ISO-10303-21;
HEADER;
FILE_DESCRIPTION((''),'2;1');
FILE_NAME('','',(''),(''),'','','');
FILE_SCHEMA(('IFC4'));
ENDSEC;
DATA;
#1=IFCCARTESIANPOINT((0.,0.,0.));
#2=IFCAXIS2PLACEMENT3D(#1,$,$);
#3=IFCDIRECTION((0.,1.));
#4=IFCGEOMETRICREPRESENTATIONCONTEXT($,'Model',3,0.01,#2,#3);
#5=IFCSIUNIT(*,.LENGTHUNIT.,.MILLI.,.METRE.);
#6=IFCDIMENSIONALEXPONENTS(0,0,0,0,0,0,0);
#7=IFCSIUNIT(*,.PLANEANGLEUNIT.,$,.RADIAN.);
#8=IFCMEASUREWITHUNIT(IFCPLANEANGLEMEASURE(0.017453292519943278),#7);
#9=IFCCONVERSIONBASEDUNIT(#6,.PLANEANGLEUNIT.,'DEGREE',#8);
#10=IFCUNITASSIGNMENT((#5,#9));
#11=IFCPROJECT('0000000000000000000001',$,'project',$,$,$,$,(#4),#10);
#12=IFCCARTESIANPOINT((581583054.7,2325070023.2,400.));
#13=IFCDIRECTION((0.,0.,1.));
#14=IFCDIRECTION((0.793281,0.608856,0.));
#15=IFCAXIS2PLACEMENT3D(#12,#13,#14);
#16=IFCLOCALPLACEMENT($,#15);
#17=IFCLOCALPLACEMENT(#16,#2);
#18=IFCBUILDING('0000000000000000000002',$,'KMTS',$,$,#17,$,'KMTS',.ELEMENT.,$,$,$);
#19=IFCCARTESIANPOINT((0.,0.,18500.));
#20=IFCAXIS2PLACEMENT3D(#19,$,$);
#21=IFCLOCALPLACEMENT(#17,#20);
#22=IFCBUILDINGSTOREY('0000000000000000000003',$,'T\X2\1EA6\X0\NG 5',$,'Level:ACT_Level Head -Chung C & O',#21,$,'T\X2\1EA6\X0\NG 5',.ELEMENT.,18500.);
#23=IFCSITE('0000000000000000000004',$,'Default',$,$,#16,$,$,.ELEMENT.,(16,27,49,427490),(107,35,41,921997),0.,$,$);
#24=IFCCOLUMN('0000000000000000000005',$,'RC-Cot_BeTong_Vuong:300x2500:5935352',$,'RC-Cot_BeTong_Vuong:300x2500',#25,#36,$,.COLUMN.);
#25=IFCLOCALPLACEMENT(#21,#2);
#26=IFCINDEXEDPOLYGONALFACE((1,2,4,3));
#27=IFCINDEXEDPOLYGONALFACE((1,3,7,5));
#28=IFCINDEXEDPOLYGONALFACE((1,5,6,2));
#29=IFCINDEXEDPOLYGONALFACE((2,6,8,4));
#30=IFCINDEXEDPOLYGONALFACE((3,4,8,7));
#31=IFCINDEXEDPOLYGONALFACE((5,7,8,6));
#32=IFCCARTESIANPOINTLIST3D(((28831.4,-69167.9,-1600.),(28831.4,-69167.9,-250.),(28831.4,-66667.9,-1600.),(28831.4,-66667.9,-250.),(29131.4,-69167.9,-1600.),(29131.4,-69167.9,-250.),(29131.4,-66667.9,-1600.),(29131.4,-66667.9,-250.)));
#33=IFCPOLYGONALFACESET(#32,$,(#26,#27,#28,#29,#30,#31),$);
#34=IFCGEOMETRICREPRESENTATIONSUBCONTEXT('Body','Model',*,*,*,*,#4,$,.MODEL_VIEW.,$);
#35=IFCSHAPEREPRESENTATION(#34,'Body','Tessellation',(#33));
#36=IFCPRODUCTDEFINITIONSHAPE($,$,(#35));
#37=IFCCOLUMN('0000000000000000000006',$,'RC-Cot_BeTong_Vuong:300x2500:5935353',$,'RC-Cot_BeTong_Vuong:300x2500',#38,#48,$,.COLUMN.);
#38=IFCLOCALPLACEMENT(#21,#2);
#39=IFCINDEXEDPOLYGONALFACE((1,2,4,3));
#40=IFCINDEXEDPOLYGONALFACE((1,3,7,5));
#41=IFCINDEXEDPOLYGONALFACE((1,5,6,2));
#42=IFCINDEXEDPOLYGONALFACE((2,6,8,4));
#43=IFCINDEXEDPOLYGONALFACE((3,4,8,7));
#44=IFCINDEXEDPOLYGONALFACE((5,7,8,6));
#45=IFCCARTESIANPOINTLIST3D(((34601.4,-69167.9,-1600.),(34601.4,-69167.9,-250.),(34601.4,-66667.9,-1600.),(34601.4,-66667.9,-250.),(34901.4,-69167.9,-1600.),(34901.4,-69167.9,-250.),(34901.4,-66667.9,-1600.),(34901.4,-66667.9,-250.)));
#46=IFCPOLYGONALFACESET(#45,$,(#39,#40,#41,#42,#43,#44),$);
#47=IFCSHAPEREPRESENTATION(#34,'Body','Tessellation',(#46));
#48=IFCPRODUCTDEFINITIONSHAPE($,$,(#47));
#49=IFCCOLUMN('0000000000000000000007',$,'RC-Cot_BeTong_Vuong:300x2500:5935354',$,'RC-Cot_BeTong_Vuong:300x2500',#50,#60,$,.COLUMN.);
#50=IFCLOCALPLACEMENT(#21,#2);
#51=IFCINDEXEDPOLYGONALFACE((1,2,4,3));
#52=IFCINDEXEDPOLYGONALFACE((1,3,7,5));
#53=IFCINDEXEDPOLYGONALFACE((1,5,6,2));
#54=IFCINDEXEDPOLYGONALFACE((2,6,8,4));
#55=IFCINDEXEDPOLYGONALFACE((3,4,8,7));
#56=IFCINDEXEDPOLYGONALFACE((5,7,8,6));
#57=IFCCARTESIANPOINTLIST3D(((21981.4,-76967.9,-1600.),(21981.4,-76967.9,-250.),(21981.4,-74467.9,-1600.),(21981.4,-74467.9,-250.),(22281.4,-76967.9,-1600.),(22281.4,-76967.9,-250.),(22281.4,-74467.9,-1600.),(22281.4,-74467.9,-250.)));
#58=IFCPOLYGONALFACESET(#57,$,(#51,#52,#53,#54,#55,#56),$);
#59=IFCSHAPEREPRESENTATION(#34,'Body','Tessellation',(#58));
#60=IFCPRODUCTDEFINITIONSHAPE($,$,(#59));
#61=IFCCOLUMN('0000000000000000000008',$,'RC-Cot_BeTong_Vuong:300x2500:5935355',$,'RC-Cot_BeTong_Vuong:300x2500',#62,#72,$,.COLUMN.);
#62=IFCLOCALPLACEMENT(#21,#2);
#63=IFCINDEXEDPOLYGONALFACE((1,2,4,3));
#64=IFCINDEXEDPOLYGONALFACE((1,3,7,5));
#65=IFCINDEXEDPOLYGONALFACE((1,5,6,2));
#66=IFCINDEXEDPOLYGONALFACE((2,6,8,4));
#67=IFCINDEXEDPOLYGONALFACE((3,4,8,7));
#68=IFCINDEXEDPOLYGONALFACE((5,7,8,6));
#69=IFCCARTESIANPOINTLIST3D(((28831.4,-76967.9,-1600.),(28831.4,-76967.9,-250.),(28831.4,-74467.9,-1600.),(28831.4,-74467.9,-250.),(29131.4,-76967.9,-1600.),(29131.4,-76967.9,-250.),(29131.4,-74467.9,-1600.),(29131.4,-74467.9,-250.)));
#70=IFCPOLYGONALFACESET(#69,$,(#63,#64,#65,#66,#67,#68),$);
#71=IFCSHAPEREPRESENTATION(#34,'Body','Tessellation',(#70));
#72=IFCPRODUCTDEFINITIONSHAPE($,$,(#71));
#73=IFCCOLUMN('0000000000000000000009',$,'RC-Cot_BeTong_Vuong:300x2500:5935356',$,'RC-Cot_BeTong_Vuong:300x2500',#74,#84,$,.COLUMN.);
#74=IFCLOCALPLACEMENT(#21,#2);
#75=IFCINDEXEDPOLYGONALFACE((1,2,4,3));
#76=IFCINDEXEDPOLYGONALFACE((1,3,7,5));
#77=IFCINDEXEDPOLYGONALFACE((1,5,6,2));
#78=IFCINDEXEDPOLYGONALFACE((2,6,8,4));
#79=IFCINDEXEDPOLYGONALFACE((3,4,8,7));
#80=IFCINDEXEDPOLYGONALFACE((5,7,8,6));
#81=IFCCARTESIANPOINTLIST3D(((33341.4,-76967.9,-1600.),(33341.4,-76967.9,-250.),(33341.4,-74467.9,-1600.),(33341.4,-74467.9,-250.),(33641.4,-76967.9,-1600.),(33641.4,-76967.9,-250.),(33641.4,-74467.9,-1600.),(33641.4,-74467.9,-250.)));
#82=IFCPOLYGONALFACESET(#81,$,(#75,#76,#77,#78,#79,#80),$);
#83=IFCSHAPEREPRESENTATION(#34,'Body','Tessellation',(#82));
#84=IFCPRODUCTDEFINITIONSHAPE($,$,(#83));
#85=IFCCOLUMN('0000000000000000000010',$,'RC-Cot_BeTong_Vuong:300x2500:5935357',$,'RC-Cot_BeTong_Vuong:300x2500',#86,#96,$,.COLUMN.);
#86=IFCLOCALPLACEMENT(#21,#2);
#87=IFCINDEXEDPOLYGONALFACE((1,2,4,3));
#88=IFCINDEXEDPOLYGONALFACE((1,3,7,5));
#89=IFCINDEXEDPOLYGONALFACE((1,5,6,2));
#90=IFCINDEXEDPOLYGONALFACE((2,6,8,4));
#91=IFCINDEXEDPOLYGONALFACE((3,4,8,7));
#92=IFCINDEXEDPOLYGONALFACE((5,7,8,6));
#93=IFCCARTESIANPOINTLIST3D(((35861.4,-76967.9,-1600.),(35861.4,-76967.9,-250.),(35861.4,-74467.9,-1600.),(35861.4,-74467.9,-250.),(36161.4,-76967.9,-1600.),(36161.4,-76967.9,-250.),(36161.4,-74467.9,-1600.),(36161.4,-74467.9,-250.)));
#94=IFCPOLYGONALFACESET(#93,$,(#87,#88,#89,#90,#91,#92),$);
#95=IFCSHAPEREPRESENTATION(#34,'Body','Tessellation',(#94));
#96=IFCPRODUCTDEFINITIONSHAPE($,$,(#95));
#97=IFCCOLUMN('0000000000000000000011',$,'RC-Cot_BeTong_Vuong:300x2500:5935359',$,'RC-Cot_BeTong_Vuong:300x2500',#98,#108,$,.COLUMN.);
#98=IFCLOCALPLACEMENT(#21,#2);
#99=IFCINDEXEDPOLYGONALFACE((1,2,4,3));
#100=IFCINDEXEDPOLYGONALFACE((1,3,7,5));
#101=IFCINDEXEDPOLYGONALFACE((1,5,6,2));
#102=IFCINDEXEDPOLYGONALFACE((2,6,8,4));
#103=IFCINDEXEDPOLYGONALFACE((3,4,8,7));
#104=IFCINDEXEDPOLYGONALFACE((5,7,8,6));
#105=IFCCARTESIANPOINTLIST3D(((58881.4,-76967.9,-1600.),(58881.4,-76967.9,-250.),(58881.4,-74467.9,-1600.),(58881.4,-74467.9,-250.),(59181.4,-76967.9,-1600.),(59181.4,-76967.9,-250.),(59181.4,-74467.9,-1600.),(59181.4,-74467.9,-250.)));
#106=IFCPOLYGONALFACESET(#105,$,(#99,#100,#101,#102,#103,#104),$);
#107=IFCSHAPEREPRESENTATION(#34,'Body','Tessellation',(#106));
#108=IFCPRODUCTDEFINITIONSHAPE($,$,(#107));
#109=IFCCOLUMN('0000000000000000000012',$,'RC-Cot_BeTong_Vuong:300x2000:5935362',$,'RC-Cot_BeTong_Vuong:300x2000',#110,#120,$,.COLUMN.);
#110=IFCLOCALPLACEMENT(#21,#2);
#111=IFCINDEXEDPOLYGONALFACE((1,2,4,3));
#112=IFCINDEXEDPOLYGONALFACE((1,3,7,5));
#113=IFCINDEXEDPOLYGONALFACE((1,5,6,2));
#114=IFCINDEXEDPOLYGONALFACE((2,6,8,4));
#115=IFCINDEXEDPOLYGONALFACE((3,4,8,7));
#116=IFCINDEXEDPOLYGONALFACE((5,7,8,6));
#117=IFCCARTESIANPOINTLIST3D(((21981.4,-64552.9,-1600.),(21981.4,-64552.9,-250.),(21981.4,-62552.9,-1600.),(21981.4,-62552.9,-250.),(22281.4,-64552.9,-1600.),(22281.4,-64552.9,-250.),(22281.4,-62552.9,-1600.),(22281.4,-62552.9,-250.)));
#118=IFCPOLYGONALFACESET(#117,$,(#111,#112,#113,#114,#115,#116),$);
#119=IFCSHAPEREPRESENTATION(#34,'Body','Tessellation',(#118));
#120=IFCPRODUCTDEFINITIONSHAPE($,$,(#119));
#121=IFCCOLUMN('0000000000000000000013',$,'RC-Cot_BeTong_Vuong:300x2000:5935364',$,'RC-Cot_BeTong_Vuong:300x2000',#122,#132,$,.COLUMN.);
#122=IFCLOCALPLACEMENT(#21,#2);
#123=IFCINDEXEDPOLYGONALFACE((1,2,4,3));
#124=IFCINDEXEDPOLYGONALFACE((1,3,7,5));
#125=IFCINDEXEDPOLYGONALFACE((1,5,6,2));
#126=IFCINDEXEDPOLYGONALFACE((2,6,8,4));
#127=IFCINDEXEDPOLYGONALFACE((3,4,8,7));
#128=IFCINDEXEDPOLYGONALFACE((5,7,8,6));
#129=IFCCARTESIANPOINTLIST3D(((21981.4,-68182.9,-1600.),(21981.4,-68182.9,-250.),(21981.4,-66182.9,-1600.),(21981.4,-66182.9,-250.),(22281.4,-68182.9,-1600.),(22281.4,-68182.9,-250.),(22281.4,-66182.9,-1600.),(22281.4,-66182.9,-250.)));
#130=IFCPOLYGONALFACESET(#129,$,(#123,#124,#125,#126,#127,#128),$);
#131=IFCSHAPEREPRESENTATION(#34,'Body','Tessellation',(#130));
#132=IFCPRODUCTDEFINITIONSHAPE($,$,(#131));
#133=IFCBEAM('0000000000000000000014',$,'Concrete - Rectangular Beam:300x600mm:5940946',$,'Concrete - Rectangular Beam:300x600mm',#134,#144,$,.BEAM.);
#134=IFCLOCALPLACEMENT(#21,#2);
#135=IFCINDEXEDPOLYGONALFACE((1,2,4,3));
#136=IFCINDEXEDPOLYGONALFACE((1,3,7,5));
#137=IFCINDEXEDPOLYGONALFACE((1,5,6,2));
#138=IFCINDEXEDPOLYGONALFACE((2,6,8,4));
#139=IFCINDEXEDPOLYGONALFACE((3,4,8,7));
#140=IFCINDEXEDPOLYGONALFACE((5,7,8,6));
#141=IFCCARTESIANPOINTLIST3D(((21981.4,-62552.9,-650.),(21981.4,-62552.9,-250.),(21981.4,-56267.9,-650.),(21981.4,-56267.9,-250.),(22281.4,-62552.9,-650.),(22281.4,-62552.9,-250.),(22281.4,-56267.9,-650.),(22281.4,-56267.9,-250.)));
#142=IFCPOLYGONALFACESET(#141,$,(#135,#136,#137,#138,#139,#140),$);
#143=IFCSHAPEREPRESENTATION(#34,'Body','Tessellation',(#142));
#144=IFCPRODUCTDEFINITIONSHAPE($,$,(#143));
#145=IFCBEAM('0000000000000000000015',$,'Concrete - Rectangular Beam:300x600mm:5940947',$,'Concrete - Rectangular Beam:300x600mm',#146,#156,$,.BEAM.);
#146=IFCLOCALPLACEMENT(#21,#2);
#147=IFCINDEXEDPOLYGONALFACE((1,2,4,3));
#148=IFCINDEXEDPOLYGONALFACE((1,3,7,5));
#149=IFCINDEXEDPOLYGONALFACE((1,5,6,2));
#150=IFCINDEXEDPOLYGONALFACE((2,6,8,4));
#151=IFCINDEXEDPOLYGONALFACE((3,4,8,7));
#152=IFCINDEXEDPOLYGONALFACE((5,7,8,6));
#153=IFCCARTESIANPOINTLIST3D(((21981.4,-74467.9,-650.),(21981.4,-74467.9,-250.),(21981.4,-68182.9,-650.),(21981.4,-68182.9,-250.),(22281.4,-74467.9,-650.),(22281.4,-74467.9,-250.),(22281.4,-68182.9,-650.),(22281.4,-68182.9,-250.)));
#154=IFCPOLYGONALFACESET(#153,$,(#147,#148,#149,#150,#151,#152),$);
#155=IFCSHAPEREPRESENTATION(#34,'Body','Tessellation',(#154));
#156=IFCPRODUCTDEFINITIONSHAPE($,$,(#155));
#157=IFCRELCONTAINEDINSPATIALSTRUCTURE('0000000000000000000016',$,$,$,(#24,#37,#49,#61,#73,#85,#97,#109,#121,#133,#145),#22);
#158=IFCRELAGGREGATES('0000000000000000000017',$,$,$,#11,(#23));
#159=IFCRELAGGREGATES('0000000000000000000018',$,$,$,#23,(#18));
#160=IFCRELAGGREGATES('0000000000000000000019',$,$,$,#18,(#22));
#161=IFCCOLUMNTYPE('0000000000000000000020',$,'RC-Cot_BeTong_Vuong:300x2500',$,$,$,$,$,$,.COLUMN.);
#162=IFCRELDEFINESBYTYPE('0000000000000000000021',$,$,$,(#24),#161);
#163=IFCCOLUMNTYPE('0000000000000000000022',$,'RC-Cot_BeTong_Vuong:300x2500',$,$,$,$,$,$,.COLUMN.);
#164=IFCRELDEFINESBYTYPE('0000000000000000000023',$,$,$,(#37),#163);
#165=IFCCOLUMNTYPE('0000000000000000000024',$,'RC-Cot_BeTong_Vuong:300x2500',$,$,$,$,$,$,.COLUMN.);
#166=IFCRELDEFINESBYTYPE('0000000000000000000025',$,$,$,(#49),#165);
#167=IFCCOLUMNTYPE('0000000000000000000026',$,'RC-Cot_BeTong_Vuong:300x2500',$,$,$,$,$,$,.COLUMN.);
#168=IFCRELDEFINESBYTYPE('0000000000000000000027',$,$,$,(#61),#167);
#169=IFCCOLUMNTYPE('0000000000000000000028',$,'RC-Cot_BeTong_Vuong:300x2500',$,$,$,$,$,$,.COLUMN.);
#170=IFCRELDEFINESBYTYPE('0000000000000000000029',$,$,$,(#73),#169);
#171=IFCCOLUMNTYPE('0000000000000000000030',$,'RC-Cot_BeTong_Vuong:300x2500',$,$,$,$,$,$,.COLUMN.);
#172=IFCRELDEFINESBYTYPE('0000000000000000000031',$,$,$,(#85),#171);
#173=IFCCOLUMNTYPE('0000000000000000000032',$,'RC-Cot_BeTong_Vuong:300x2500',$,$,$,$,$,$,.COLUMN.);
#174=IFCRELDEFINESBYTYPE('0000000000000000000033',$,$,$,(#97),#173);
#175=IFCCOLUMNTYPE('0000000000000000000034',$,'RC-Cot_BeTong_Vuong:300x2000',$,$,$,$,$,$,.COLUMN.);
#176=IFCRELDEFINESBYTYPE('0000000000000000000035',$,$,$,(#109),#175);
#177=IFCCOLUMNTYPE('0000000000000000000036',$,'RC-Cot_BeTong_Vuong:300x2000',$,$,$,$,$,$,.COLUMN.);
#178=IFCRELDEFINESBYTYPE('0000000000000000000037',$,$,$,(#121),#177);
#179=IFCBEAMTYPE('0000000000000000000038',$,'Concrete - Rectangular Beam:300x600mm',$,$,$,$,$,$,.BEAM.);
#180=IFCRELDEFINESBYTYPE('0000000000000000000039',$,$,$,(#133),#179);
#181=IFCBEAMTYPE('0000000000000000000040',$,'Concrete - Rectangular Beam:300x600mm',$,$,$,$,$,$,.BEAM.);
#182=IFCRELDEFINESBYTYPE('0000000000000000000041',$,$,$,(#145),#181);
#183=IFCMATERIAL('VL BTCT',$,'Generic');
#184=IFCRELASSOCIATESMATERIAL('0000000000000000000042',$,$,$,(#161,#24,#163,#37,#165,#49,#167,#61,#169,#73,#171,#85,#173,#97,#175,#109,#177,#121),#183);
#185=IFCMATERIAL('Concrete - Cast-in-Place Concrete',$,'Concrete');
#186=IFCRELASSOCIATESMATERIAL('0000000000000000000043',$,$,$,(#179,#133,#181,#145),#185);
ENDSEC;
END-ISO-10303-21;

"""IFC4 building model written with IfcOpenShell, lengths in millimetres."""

from ifc_helpers import new_model, entity, si_unit, converted_unit, direction, frame, origin, place, context, subcontext, project, spatial, indexed_curve, outline, extrude, source, transform, mapped, material, type_object, type_shapes, element, save


model = new_model("IFC4")

# Units and contexts
model_context = context("Model", 3, precision=0.01, world=origin(), true_north=direction((0.0, 1.0)))
body_context = subcontext(model_context, "Body", "Model", "MODEL_VIEW")
ifc_project = project(units=[si_unit("LENGTHUNIT", "METRE", prefix="MILLI"), converted_unit("PLANEANGLEUNIT", "DEGREE", entity("IfcPlaneAngleMeasure", 0.017453292519943278), si_unit("PLANEANGLEUNIT", "RADIAN"), dimensions=[0, 0, 0, 0, 0, 0, 0])], contexts=[model_context])

# Site, building, storey
site_placement = place(None, frame((581583054.7, 2325070023.2, 400.0), z_axis=(0.0, 0.0, 1.0), x_axis=(0.793281, 0.608856, 0.0)))
site = spatial("IfcSite", under=ifc_project, at=site_placement, Name="Default", CompositionType="ELEMENT", RefLatitude=(16, 27, 49, 427490), RefLongitude=(107, 35, 41, 921997), RefElevation=0.0)
building_placement = place(site_placement, origin())
building = spatial("IfcBuilding", under=site, at=building_placement, Name="KMTS", LongName="KMTS", CompositionType="ELEMENT")
storey_placement = place(building_placement, frame((0.0, 0.0, 18500.0)))
storey = spatial("IfcBuildingStorey", under=building, at=storey_placement, Name="TẦNG 5", ObjectType="Level:ACT_Level Head -Chung C & O", LongName="TẦNG 5", CompositionType="ELEMENT", Elevation=18500.0)

# Columns
ifc_material_1 = material(Name="VL BTCT", Category="Generic")
column_type_1 = type_object("IfcColumnType", Name="RC-Cot_BeTong_Vuong:300x2500", PredefinedType="COLUMN", material=ifc_material_1)
shared_shape_1 = source(origin(), body_context, "Body", "SweptSolid", [
    extrude(outline(indexed_curve([(-675.0, -1250.0), (675.0, -1250.0), (675.0, 1250.0), (-675.0, 1250.0), (-675.0, -1250.0)], self_intersect=False)), frame((28831.4, -67917.9, 17575.0), z_axis=(1.0, 0.0, 0.0), x_axis=(0.0, 0.0, 1.0)), (0.0, 0.0, 1.0), 300.0),
])
type_shapes(column_type_1, [shared_shape_1])
column_1_placement = place(storey_placement, frame((0.0, 0.0, -18500.0)))
element("IfcColumn", 1, at=column_1_placement, inside=storey, type_object=column_type_1, material=ifc_material_1, Name="RC-Cot_BeTong_Vuong:300x2500:5935352", ObjectType="RC-Cot_BeTong_Vuong:300x2500", PredefinedType="COLUMN", context=body_context, shape_type="MappedRepresentation", body=[
    mapped(shared_shape_1, transform((0.0, 0.0, 0.0), scale=1.0)),
])
column_type_2 = type_object("IfcColumnType", Name="RC-Cot_BeTong_Vuong:300x2500", PredefinedType="COLUMN", material=ifc_material_1)
shared_shape_2 = source(origin(), body_context, "Body", "SweptSolid", [
    extrude(outline(indexed_curve([(-675.0, -1250.0), (675.0, -1250.0), (675.0, 1250.0), (-675.0, 1250.0), (-675.0, -1250.0)], self_intersect=False)), frame((34601.4, -67917.9, 17575.0), z_axis=(1.0, 0.0, 0.0), x_axis=(0.0, 0.0, 1.0)), (0.0, 0.0, 1.0), 300.0),
])
type_shapes(column_type_2, [shared_shape_2])
column_2_placement = place(storey_placement, frame((0.0, 0.0, -18500.0)))
element("IfcColumn", 2, at=column_2_placement, inside=storey, type_object=column_type_2, material=ifc_material_1, Name="RC-Cot_BeTong_Vuong:300x2500:5935353", ObjectType="RC-Cot_BeTong_Vuong:300x2500", PredefinedType="COLUMN", context=body_context, shape_type="MappedRepresentation", body=[
    mapped(shared_shape_2, transform((0.0, 0.0, 0.0), scale=1.0)),
])
column_type_3 = type_object("IfcColumnType", Name="RC-Cot_BeTong_Vuong:300x2500", PredefinedType="COLUMN", material=ifc_material_1)
shared_shape_3 = source(origin(), body_context, "Body", "SweptSolid", [
    extrude(outline(indexed_curve([(-675.0, -1250.0), (675.0, -1250.0), (675.0, 1250.0), (-675.0, 1250.0), (-675.0, -1250.0)], self_intersect=False)), frame((21981.4, -75717.9, 17575.0), z_axis=(1.0, 0.0, 0.0), x_axis=(0.0, 0.0, 1.0)), (0.0, 0.0, 1.0), 300.0),
])
type_shapes(column_type_3, [shared_shape_3])
column_3_placement = place(storey_placement, frame((0.0, 0.0, -18500.0)))
element("IfcColumn", 3, at=column_3_placement, inside=storey, type_object=column_type_3, material=ifc_material_1, Name="RC-Cot_BeTong_Vuong:300x2500:5935354", ObjectType="RC-Cot_BeTong_Vuong:300x2500", PredefinedType="COLUMN", context=body_context, shape_type="MappedRepresentation", body=[
    mapped(shared_shape_3, transform((0.0, 0.0, 0.0), scale=1.0)),
])
column_type_4 = type_object("IfcColumnType", Name="RC-Cot_BeTong_Vuong:300x2500", PredefinedType="COLUMN", material=ifc_material_1)
shared_shape_4 = source(origin(), body_context, "Body", "SweptSolid", [
    extrude(outline(indexed_curve([(-675.0, -1250.0), (675.0, -1250.0), (675.0, 1250.0), (-675.0, 1250.0), (-675.0, -1250.0)], self_intersect=False)), frame((28831.4, -75717.9, 17575.0), z_axis=(1.0, 0.0, 0.0), x_axis=(0.0, 0.0, 1.0)), (0.0, 0.0, 1.0), 300.0),
])
type_shapes(column_type_4, [shared_shape_4])
column_4_placement = place(storey_placement, frame((0.0, 0.0, -18500.0)))
element("IfcColumn", 4, at=column_4_placement, inside=storey, type_object=column_type_4, material=ifc_material_1, Name="RC-Cot_BeTong_Vuong:300x2500:5935355", ObjectType="RC-Cot_BeTong_Vuong:300x2500", PredefinedType="COLUMN", context=body_context, shape_type="MappedRepresentation", body=[
    mapped(shared_shape_4, transform((0.0, 0.0, 0.0), scale=1.0)),
])
column_type_5 = type_object("IfcColumnType", Name="RC-Cot_BeTong_Vuong:300x2500", PredefinedType="COLUMN", material=ifc_material_1)
shared_shape_5 = source(origin(), body_context, "Body", "SweptSolid", [
    extrude(outline(indexed_curve([(-675.0, -1250.0), (675.0, -1250.0), (675.0, 1250.0), (-675.0, 1250.0), (-675.0, -1250.0)], self_intersect=False)), frame((33341.4, -75717.9, 17575.0), z_axis=(1.0, 0.0, 0.0), x_axis=(0.0, 0.0, 1.0)), (0.0, 0.0, 1.0), 300.0),
])
type_shapes(column_type_5, [shared_shape_5])
column_5_placement = place(storey_placement, frame((0.0, 0.0, -18500.0)))
element("IfcColumn", 5, at=column_5_placement, inside=storey, type_object=column_type_5, material=ifc_material_1, Name="RC-Cot_BeTong_Vuong:300x2500:5935356", ObjectType="RC-Cot_BeTong_Vuong:300x2500", PredefinedType="COLUMN", context=body_context, shape_type="MappedRepresentation", body=[
    mapped(shared_shape_5, transform((0.0, 0.0, 0.0), scale=1.0)),
])
column_type_6 = type_object("IfcColumnType", Name="RC-Cot_BeTong_Vuong:300x2500", PredefinedType="COLUMN", material=ifc_material_1)
shared_shape_6 = source(origin(), body_context, "Body", "SweptSolid", [
    extrude(outline(indexed_curve([(-675.0, -1250.0), (675.0, -1250.0), (675.0, 1250.0), (-675.0, 1250.0), (-675.0, -1250.0)], self_intersect=False)), frame((35861.4, -75717.9, 17575.0), z_axis=(1.0, 0.0, 0.0), x_axis=(0.0, 0.0, 1.0)), (0.0, 0.0, 1.0), 300.0),
])
type_shapes(column_type_6, [shared_shape_6])
column_6_placement = place(storey_placement, frame((0.0, 0.0, -18500.0)))
element("IfcColumn", 6, at=column_6_placement, inside=storey, type_object=column_type_6, material=ifc_material_1, Name="RC-Cot_BeTong_Vuong:300x2500:5935357", ObjectType="RC-Cot_BeTong_Vuong:300x2500", PredefinedType="COLUMN", context=body_context, shape_type="MappedRepresentation", body=[
    mapped(shared_shape_6, transform((0.0, 0.0, 0.0), scale=1.0)),
])
column_type_7 = type_object("IfcColumnType", Name="RC-Cot_BeTong_Vuong:300x2500", PredefinedType="COLUMN", material=ifc_material_1)
shared_shape_7 = source(origin(), body_context, "Body", "SweptSolid", [
    extrude(outline(indexed_curve([(-675.0, -1250.0), (675.0, -1250.0), (675.0, 1250.0), (-675.0, 1250.0), (-675.0, -1250.0)], self_intersect=False)), frame((58881.4, -75717.9, 17575.0), z_axis=(1.0, 0.0, 0.0), x_axis=(0.0, 0.0, 1.0)), (0.0, 0.0, 1.0), 300.0),
])
type_shapes(column_type_7, [shared_shape_7])
column_7_placement = place(storey_placement, frame((0.0, 0.0, -18500.0)))
element("IfcColumn", 7, at=column_7_placement, inside=storey, type_object=column_type_7, material=ifc_material_1, Name="RC-Cot_BeTong_Vuong:300x2500:5935359", ObjectType="RC-Cot_BeTong_Vuong:300x2500", PredefinedType="COLUMN", context=body_context, shape_type="MappedRepresentation", body=[
    mapped(shared_shape_7, transform((0.0, 0.0, 0.0), scale=1.0)),
])
column_type_8 = type_object("IfcColumnType", Name="RC-Cot_BeTong_Vuong:300x2000", PredefinedType="COLUMN", material=ifc_material_1)
shared_shape_8 = source(origin(), body_context, "Body", "SweptSolid", [
    extrude(outline(indexed_curve([(-675.0, -1000.0), (675.0, -1000.0), (675.0, 1000.0), (-675.0, 1000.0), (-675.0, -1000.0)], self_intersect=False)), frame((21981.4, -63552.9, 17575.0), z_axis=(1.0, 0.0, 0.0), x_axis=(0.0, 0.0, 1.0)), (0.0, 0.0, 1.0), 300.0),
])
type_shapes(column_type_8, [shared_shape_8])
column_8_placement = place(storey_placement, frame((0.0, 0.0, -18500.0)))
element("IfcColumn", 8, at=column_8_placement, inside=storey, type_object=column_type_8, material=ifc_material_1, Name="RC-Cot_BeTong_Vuong:300x2000:5935362", ObjectType="RC-Cot_BeTong_Vuong:300x2000", PredefinedType="COLUMN", context=body_context, shape_type="MappedRepresentation", body=[
    mapped(shared_shape_8, transform((0.0, 0.0, 0.0), scale=1.0)),
])
column_type_9 = type_object("IfcColumnType", Name="RC-Cot_BeTong_Vuong:300x2000", PredefinedType="COLUMN", material=ifc_material_1)
shared_shape_9 = source(origin(), body_context, "Body", "SweptSolid", [
    extrude(outline(indexed_curve([(-675.0, -1000.0), (675.0, -1000.0), (675.0, 1000.0), (-675.0, 1000.0), (-675.0, -1000.0)], self_intersect=False)), frame((21981.4, -67182.9, 17575.0), z_axis=(1.0, 0.0, 0.0), x_axis=(0.0, 0.0, 1.0)), (0.0, 0.0, 1.0), 300.0),
])
type_shapes(column_type_9, [shared_shape_9])
column_9_placement = place(storey_placement, frame((0.0, 0.0, -18500.0)))
element("IfcColumn", 9, at=column_9_placement, inside=storey, type_object=column_type_9, material=ifc_material_1, Name="RC-Cot_BeTong_Vuong:300x2000:5935364", ObjectType="RC-Cot_BeTong_Vuong:300x2000", PredefinedType="COLUMN", context=body_context, shape_type="MappedRepresentation", body=[
    mapped(shared_shape_9, transform((0.0, 0.0, 0.0), scale=1.0)),
])

# Beams
ifc_material_2 = material(Name="Concrete - Cast-in-Place Concrete", Category="Concrete")
beam_type_1 = type_object("IfcBeamType", Name="Concrete - Rectangular Beam:300x600mm", PredefinedType="BEAM", material=ifc_material_2)
shared_shape_10 = source(origin(), body_context, "Body", "SweptSolid", [
    extrude(outline(indexed_curve([(-150.0, -200.0), (150.0, -200.0), (150.0, 200.0), (-150.0, 200.0), (-150.0, -200.0)], self_intersect=False)), frame((22131.4, -62552.9, 18050.0), z_axis=(0.0, 1.0, 0.0), x_axis=(-1.0, 0.0, 0.0)), (0.0, 0.0, 1.0), 6285.0),
])
type_shapes(beam_type_1, [shared_shape_10])
beam_1_placement = place(storey_placement, frame((0.0, 0.0, -18500.0)))
element("IfcBeam", 10, at=beam_1_placement, inside=storey, type_object=beam_type_1, material=ifc_material_2, Name="Concrete - Rectangular Beam:300x600mm:5940946", ObjectType="Concrete - Rectangular Beam:300x600mm", PredefinedType="BEAM", context=body_context, shape_type="MappedRepresentation", body=[
    mapped(shared_shape_10, transform((0.0, 0.0, 0.0), scale=1.0)),
])
beam_type_2 = type_object("IfcBeamType", Name="Concrete - Rectangular Beam:300x600mm", PredefinedType="BEAM", material=ifc_material_2)
shared_shape_11 = source(origin(), body_context, "Body", "SweptSolid", [
    extrude(outline(indexed_curve([(-150.0, -200.0), (150.0, -200.0), (150.0, 200.0), (-150.0, 200.0), (-150.0, -200.0)], self_intersect=False)), frame((22131.4, -68182.9, 18050.0), z_axis=(0.0, -1.0, 0.0), x_axis=(-1.0, 0.0, 0.0)), (0.0, 0.0, 1.0), 6285.0),
])
type_shapes(beam_type_2, [shared_shape_11])
beam_2_placement = place(storey_placement, frame((0.0, 0.0, -18500.0)))
element("IfcBeam", 11, at=beam_2_placement, inside=storey, type_object=beam_type_2, material=ifc_material_2, Name="Concrete - Rectangular Beam:300x600mm:5940947", ObjectType="Concrete - Rectangular Beam:300x600mm", PredefinedType="BEAM", context=body_context, shape_type="MappedRepresentation", body=[
    mapped(shared_shape_11, transform((0.0, 0.0, 0.0), scale=1.0)),
])

save(model, "model.ifc")
